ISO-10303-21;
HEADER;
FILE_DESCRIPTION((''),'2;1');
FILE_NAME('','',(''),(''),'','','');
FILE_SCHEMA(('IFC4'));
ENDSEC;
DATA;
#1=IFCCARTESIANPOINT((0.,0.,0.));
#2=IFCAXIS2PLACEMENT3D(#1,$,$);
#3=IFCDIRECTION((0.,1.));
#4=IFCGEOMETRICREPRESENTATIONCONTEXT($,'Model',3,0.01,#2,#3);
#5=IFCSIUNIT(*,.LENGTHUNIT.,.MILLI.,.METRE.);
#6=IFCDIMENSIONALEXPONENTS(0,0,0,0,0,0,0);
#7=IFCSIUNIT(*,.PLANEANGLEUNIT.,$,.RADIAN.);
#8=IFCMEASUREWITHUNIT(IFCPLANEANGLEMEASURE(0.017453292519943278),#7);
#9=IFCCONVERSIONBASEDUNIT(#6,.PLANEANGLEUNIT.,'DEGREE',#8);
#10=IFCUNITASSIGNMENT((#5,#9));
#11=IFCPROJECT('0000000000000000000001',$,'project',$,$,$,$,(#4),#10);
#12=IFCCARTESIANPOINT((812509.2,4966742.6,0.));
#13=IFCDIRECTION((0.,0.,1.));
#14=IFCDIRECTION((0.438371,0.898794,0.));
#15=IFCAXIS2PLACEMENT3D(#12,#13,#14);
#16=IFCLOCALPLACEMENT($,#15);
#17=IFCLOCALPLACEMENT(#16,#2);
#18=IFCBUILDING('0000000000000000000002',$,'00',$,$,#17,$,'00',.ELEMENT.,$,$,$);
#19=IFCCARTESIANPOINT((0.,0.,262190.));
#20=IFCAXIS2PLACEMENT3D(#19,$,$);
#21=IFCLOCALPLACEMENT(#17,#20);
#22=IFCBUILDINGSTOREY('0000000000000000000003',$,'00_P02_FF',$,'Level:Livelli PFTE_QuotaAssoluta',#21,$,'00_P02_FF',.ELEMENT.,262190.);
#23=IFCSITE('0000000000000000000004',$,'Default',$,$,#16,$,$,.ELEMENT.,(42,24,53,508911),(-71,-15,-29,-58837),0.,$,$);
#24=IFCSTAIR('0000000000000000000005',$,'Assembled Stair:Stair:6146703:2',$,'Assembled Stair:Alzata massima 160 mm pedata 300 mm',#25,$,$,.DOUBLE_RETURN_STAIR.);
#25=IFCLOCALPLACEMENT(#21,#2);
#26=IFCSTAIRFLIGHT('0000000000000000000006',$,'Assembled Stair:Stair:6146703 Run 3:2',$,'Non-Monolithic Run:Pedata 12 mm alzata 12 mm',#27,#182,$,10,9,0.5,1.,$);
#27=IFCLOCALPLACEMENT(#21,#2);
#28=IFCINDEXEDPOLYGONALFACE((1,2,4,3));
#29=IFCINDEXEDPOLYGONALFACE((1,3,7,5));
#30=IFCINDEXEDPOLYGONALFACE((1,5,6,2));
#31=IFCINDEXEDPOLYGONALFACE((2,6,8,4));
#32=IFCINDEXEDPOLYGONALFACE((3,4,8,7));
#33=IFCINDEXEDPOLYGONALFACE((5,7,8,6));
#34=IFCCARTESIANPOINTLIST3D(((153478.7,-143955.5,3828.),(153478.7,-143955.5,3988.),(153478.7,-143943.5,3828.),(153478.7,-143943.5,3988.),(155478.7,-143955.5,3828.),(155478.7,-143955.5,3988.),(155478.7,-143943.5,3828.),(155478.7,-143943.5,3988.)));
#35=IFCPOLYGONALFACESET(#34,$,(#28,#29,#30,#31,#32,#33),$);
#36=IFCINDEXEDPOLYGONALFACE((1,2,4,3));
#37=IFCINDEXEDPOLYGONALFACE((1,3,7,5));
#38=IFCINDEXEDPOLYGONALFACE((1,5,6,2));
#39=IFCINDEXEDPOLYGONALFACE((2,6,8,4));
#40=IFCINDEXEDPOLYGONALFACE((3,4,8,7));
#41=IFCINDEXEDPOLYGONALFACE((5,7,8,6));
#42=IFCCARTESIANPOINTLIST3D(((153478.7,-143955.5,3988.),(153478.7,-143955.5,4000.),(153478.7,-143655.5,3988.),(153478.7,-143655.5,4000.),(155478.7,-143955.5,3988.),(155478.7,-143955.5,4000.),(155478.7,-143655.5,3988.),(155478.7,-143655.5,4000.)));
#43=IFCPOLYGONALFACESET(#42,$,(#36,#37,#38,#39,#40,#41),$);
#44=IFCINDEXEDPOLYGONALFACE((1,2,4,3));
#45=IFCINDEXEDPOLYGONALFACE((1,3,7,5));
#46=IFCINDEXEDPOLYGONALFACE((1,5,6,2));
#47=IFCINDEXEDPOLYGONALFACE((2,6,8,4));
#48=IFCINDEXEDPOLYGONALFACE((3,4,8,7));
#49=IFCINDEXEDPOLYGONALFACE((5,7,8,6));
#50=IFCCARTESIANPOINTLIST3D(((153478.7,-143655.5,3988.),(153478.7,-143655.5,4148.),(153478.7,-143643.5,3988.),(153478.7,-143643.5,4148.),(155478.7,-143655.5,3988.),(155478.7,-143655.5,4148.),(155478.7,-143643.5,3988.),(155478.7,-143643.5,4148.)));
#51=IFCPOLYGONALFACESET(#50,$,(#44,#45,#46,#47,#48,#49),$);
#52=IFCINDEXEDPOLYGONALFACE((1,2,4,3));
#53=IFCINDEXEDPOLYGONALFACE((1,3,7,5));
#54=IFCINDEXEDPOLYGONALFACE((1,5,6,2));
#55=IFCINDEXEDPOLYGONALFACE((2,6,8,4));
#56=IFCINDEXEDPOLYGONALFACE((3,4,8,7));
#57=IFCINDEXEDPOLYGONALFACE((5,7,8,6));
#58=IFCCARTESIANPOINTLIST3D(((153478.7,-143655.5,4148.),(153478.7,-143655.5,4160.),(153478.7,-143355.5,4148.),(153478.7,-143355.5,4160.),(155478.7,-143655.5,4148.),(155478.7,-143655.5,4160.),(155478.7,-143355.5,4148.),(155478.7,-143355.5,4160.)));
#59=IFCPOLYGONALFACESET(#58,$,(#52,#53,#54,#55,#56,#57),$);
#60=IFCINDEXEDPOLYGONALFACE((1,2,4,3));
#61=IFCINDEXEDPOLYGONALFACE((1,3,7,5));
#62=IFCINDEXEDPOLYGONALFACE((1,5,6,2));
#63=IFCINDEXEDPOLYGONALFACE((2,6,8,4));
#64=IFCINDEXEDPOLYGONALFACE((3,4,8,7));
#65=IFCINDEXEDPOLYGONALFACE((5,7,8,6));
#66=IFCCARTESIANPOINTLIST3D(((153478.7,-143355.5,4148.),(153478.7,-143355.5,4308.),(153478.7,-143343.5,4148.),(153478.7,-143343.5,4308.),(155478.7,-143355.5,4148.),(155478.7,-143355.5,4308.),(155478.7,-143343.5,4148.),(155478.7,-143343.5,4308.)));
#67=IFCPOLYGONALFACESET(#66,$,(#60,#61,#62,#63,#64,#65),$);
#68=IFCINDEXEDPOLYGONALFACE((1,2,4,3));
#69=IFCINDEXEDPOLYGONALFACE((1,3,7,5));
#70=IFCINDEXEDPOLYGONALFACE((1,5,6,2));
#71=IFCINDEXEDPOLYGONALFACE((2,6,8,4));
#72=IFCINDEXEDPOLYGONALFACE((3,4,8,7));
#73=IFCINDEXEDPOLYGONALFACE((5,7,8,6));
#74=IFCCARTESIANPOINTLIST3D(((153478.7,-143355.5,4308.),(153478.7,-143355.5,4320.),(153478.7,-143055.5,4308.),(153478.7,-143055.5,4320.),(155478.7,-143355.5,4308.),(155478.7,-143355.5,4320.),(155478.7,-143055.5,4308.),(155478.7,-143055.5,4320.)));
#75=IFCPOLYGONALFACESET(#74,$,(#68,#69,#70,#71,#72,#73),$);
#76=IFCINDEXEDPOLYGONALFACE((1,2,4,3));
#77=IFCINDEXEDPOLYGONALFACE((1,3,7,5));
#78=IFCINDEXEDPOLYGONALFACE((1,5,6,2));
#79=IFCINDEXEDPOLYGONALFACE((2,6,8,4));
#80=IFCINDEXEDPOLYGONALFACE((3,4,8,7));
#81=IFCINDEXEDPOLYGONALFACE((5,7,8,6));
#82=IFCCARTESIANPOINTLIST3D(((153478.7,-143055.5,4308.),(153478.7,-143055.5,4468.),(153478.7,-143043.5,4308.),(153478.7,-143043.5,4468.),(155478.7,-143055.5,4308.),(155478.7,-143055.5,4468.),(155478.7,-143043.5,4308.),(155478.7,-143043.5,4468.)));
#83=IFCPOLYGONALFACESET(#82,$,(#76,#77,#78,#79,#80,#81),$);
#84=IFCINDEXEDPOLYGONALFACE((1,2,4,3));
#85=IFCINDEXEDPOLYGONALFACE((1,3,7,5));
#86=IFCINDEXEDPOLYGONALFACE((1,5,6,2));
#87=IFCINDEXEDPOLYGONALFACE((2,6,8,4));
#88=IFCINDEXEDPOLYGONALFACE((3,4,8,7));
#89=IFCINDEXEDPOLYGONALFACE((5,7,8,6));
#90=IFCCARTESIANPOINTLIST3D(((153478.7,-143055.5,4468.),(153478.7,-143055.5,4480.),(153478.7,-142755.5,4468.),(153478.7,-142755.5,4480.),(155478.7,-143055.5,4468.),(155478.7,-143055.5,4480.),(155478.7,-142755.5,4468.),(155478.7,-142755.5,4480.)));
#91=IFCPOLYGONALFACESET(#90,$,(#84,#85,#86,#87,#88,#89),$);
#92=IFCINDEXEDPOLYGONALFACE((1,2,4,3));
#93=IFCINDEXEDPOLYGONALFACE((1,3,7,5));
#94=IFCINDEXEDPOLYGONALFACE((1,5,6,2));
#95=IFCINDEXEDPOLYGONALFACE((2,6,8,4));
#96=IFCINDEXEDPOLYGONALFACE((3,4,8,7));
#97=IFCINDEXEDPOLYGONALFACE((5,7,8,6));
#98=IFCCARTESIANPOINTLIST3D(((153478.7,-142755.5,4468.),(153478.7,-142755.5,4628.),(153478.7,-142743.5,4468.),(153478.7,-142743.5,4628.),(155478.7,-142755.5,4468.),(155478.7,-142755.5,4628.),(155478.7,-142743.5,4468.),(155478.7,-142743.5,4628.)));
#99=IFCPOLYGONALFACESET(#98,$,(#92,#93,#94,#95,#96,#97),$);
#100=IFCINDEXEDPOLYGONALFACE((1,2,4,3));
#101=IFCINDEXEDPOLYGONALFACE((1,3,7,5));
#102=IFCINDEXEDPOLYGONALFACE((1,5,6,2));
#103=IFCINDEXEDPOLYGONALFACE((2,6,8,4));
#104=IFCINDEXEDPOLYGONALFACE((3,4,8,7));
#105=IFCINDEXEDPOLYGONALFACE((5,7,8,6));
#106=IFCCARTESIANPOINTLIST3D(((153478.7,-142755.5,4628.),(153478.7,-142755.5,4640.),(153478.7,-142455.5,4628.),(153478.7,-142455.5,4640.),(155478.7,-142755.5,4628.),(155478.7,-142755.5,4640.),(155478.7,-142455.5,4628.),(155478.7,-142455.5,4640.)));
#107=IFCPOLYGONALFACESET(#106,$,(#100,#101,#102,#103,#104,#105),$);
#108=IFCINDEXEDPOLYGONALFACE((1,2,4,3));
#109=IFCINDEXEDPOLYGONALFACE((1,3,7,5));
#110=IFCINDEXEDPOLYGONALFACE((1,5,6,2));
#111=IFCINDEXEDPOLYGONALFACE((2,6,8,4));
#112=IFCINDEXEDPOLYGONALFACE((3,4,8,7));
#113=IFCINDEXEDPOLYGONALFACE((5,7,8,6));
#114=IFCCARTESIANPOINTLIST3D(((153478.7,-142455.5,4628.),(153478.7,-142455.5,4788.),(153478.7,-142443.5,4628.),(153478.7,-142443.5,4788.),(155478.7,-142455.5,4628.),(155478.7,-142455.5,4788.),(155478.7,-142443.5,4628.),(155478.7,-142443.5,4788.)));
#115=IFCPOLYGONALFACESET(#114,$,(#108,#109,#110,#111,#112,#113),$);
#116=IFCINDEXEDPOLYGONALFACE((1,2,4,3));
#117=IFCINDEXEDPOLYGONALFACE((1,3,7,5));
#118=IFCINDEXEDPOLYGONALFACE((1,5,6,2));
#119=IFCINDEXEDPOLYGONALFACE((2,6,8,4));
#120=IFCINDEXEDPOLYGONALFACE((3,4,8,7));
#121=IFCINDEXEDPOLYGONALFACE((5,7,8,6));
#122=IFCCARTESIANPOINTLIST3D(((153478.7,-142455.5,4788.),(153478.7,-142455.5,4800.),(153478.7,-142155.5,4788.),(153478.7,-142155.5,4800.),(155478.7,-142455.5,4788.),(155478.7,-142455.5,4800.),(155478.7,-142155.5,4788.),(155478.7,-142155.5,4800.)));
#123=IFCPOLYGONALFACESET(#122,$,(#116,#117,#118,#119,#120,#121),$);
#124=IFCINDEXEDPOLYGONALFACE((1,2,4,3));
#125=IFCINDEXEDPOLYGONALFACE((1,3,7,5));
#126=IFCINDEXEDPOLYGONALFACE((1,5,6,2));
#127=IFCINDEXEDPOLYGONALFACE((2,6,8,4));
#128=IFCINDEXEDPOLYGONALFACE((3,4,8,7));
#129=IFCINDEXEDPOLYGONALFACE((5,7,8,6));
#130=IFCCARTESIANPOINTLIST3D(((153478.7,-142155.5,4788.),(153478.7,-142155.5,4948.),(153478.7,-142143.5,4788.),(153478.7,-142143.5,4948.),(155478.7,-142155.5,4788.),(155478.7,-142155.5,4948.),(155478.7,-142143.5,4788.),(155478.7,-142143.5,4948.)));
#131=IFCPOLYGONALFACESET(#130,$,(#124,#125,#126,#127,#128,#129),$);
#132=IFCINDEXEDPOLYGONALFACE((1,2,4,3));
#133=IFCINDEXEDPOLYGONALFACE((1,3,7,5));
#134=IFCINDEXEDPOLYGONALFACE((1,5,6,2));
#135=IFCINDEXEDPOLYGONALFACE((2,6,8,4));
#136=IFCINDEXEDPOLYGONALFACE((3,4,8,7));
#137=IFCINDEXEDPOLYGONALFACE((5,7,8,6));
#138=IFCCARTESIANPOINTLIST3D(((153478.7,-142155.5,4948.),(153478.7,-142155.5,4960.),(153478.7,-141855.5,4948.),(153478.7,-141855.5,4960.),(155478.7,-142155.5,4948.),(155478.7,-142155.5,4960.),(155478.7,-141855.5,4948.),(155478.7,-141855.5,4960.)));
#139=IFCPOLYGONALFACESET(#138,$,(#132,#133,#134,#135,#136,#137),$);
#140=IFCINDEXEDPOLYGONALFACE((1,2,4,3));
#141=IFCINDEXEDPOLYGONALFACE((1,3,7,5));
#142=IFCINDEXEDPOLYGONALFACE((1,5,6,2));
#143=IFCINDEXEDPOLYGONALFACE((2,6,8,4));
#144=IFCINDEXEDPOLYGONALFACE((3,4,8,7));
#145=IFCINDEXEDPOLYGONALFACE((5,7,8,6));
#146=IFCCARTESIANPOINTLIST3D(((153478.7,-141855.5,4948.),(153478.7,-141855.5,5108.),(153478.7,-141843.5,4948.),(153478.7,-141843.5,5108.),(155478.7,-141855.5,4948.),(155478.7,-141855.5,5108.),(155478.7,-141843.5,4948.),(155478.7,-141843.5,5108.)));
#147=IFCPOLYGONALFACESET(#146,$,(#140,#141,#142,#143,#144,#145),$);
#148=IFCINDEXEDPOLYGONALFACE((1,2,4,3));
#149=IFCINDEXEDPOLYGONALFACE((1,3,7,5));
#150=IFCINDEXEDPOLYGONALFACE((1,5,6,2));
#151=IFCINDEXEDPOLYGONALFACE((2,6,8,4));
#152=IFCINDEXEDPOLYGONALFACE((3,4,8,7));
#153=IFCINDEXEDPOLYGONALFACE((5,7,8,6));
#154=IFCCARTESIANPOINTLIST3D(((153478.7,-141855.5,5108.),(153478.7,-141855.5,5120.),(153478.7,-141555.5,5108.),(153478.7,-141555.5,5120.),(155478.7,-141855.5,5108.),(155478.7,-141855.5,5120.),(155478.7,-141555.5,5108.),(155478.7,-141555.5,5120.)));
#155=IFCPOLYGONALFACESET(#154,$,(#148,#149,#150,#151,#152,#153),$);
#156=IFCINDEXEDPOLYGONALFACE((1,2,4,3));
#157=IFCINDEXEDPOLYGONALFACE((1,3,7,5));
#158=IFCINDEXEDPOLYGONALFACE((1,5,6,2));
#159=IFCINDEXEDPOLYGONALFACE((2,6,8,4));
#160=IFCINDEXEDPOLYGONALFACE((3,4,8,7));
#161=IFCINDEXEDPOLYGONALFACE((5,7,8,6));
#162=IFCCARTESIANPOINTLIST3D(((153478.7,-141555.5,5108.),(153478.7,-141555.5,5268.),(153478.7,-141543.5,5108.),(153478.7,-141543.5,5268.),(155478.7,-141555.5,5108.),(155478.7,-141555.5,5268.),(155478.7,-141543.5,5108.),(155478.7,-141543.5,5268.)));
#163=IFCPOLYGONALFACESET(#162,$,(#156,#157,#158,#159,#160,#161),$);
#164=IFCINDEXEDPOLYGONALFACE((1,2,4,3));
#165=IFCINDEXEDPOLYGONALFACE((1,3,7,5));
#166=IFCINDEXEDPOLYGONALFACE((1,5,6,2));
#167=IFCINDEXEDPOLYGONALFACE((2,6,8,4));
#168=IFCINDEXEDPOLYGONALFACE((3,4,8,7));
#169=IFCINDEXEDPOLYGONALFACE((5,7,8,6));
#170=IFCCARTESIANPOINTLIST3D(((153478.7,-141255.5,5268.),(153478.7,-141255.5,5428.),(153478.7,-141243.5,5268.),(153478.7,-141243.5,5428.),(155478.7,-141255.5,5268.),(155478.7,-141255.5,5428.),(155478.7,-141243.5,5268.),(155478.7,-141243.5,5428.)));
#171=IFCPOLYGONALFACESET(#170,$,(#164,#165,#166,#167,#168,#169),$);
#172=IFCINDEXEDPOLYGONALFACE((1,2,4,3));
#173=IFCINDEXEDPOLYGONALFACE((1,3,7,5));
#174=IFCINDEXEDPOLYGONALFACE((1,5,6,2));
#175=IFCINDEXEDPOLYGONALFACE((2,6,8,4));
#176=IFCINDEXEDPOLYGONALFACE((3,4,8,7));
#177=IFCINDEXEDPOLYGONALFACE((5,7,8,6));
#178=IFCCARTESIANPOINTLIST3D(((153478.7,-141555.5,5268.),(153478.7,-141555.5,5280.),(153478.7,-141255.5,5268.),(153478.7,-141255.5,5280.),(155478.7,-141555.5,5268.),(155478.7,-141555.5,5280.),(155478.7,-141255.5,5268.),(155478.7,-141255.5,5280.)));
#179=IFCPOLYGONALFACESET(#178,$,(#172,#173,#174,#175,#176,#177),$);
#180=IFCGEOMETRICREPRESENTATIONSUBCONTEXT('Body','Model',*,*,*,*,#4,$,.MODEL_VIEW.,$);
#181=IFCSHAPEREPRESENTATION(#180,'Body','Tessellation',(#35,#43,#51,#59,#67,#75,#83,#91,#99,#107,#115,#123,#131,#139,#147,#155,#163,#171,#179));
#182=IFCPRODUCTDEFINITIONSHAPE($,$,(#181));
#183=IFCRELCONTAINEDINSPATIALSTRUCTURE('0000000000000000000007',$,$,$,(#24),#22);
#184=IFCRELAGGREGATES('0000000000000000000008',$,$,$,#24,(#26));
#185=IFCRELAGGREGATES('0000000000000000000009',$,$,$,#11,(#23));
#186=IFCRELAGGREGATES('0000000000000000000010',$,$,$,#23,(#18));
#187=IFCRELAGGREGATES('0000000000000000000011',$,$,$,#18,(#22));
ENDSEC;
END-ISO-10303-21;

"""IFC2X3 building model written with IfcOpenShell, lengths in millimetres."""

from ifc_helpers import new_model, entity, si_unit, converted_unit, direction, frame, frame_2d, origin, place, context, subcontext, project, spatial, rectangle, extrude, element, aggregate, save


model = new_model("IFC2X3")

# Units and contexts
model_context = context("Model", 3, precision=0.01, world=origin(), true_north=direction((0.0, 1.0)))
body_context = subcontext(model_context, "Body", "Model", "MODEL_VIEW")
ifc_project = project(units=[si_unit("LENGTHUNIT", "METRE", prefix="MILLI"), converted_unit("PLANEANGLEUNIT", "DEGREE", entity("IfcPlaneAngleMeasure", 0.017453292519943278), si_unit("PLANEANGLEUNIT", "RADIAN"), dimensions=[0, 0, 0, 0, 0, 0, 0])], contexts=[model_context])

# Site, building, storey
site_placement = place(None, frame((812509.2, 4966742.6, 0.0), z_axis=(0.0, 0.0, 1.0), x_axis=(0.438371, 0.898794, 0.0)))
site = spatial("IfcSite", under=ifc_project, at=site_placement, Name="Default", CompositionType="ELEMENT", RefLatitude=(42, 24, 53, 508911), RefLongitude=(-71, -15, -29, -58837), RefElevation=0.0)
building_placement = place(site_placement, origin())
building = spatial("IfcBuilding", under=site, at=building_placement, Name="00", LongName="00", CompositionType="ELEMENT")
storey_placement = place(building_placement, frame((0.0, 0.0, 262190.0)))
storey = spatial("IfcBuildingStorey", under=building, at=storey_placement, Name="00_P02_FF", ObjectType="Level:Livelli PFTE_QuotaAssoluta", LongName="00_P02_FF", CompositionType="ELEMENT", Elevation=262190.0)

# Stair
stair_1_placement = place(storey_placement, origin())
stair_1 = element("IfcStair", 1, at=stair_1_placement, inside=storey, Name="Assembled Stair:Stair:6146703:2", ObjectType="Assembled Stair:Alzata massima 160 mm pedata 300 mm", ShapeType="DOUBLE_RETURN_STAIR")

# Stair flight
stair_flight_1_placement = place(stair_1_placement, origin())
stair_flight_1 = element("IfcStairFlight", 2, at=stair_flight_1_placement, Name="Assembled Stair:Stair:6146703 Run 3:2", ObjectType="Non-Monolithic Run:Pedata 12 mm alzata 12 mm", NumberOfRiser=10, NumberOfTreads=9, RiserHeight=0.5, TreadLength=1.0, context=body_context, shape_type="SweptSolid", body=[
    extrude(rectangle(XDim=2000.0, YDim=12.0, at=frame_2d((0.0, 0.0), x_axis=(1.0, 0.0))), frame((154478.7, -143949.5, 3828.0), z_axis=(0.0, 0.0, 1.0), x_axis=(-1.0, 0.0, 0.0)), (0.0, 0.0, 1.0), 160.0),
    extrude(rectangle(XDim=300.0, YDim=2000.0, at=frame_2d((0.0, 0.0), x_axis=(1.0, 0.0))), frame((154478.7, -143805.5, 3988.0), z_axis=(0.0, 0.0, 1.0), x_axis=(0.0, -1.0, 0.0)), (0.0, 0.0, 1.0), 12.0),
    extrude(rectangle(XDim=2000.0, YDim=12.0, at=frame_2d((0.0, 0.0), x_axis=(1.0, 0.0))), frame((154478.7, -143649.5, 3988.0), z_axis=(0.0, 0.0, 1.0), x_axis=(-1.0, 0.0, 0.0)), (0.0, 0.0, 1.0), 160.0),
    extrude(rectangle(XDim=300.0, YDim=2000.0, at=frame_2d((0.0, 0.0), x_axis=(1.0, 0.0))), frame((154478.7, -143505.5, 4148.0), z_axis=(0.0, 0.0, 1.0), x_axis=(0.0, -1.0, 0.0)), (0.0, 0.0, 1.0), 12.0),
    extrude(rectangle(XDim=2000.0, YDim=12.0, at=frame_2d((0.0, 0.0), x_axis=(1.0, 0.0))), frame((154478.7, -143349.5, 4148.0), z_axis=(0.0, 0.0, 1.0), x_axis=(-1.0, 0.0, 0.0)), (0.0, 0.0, 1.0), 160.0),
    extrude(rectangle(XDim=300.0, YDim=2000.0, at=frame_2d((0.0, 0.0), x_axis=(1.0, 0.0))), frame((154478.7, -143205.5, 4308.0), z_axis=(0.0, 0.0, 1.0), x_axis=(0.0, -1.0, 0.0)), (0.0, 0.0, 1.0), 12.0),
    extrude(rectangle(XDim=2000.0, YDim=12.0, at=frame_2d((0.0, 0.0), x_axis=(1.0, 0.0))), frame((154478.7, -143049.5, 4308.0), z_axis=(0.0, 0.0, 1.0), x_axis=(-1.0, 0.0, 0.0)), (0.0, 0.0, 1.0), 160.0),
    extrude(rectangle(XDim=300.0, YDim=2000.0, at=frame_2d((0.0, 0.0), x_axis=(1.0, 0.0))), frame((154478.7, -142905.5, 4468.0), z_axis=(0.0, 0.0, 1.0), x_axis=(0.0, -1.0, 0.0)), (0.0, 0.0, 1.0), 12.0),
    extrude(rectangle(XDim=2000.0, YDim=12.0, at=frame_2d((0.0, 0.0), x_axis=(1.0, 0.0))), frame((154478.7, -142749.5, 4468.0), z_axis=(0.0, 0.0, 1.0), x_axis=(-1.0, 0.0, 0.0)), (0.0, 0.0, 1.0), 160.0),
    extrude(rectangle(XDim=300.0, YDim=2000.0, at=frame_2d((0.0, 0.0), x_axis=(1.0, 0.0))), frame((154478.7, -142605.5, 4628.0), z_axis=(0.0, 0.0, 1.0), x_axis=(0.0, -1.0, 0.0)), (0.0, 0.0, 1.0), 12.0),
    extrude(rectangle(XDim=2000.0, YDim=12.0, at=frame_2d((0.0, 0.0), x_axis=(1.0, 0.0))), frame((154478.7, -142449.5, 4628.0), z_axis=(0.0, 0.0, 1.0), x_axis=(-1.0, 0.0, 0.0)), (0.0, 0.0, 1.0), 160.0),
    extrude(rectangle(XDim=300.0, YDim=2000.0, at=frame_2d((0.0, 0.0), x_axis=(1.0, 0.0))), frame((154478.7, -142305.5, 4788.0), z_axis=(0.0, 0.0, 1.0), x_axis=(0.0, -1.0, 0.0)), (0.0, 0.0, 1.0), 12.0),
    extrude(rectangle(XDim=2000.0, YDim=12.0, at=frame_2d((0.0, 0.0), x_axis=(1.0, 0.0))), frame((154478.7, -142149.5, 4788.0), z_axis=(0.0, 0.0, 1.0), x_axis=(-1.0, 0.0, 0.0)), (0.0, 0.0, 1.0), 160.0),
    extrude(rectangle(XDim=300.0, YDim=2000.0, at=frame_2d((0.0, 0.0), x_axis=(1.0, 0.0))), frame((154478.7, -142005.5, 4948.0), z_axis=(0.0, 0.0, 1.0), x_axis=(0.0, -1.0, 0.0)), (0.0, 0.0, 1.0), 12.0),
    extrude(rectangle(XDim=2000.0, YDim=12.0, at=frame_2d((0.0, 0.0), x_axis=(1.0, 0.0))), frame((154478.7, -141849.5, 4948.0), z_axis=(0.0, 0.0, 1.0), x_axis=(-1.0, 0.0, 0.0)), (0.0, 0.0, 1.0), 160.0),
    extrude(rectangle(XDim=300.0, YDim=2000.0, at=frame_2d((0.0, 0.0), x_axis=(1.0, 0.0))), frame((154478.7, -141705.5, 5108.0), z_axis=(0.0, 0.0, 1.0), x_axis=(0.0, -1.0, 0.0)), (0.0, 0.0, 1.0), 12.0),
    extrude(rectangle(XDim=2000.0, YDim=12.0, at=frame_2d((0.0, 0.0), x_axis=(1.0, 0.0))), frame((154478.7, -141549.5, 5108.0), z_axis=(0.0, 0.0, 1.0), x_axis=(-1.0, 0.0, 0.0)), (0.0, 0.0, 1.0), 160.0),
    extrude(rectangle(XDim=2000.0, YDim=12.0, at=frame_2d((0.0, 0.0), x_axis=(1.0, 0.0))), frame((154478.7, -141249.5, 5268.0), z_axis=(0.0, 0.0, 1.0), x_axis=(-1.0, 0.0, 0.0)), (0.0, 0.0, 1.0), 160.0),
    extrude(rectangle(XDim=300.0, YDim=2000.0, at=frame_2d((0.0, 0.0), x_axis=(1.0, 0.0))), frame((154478.7, -141405.5, 5268.0), z_axis=(0.0, 0.0, 1.0), x_axis=(0.0, -1.0, 0.0)), (0.0, 0.0, 1.0), 12.0),
])
aggregate(stair_1, [stair_flight_1])

save(model, "model.ifc")
